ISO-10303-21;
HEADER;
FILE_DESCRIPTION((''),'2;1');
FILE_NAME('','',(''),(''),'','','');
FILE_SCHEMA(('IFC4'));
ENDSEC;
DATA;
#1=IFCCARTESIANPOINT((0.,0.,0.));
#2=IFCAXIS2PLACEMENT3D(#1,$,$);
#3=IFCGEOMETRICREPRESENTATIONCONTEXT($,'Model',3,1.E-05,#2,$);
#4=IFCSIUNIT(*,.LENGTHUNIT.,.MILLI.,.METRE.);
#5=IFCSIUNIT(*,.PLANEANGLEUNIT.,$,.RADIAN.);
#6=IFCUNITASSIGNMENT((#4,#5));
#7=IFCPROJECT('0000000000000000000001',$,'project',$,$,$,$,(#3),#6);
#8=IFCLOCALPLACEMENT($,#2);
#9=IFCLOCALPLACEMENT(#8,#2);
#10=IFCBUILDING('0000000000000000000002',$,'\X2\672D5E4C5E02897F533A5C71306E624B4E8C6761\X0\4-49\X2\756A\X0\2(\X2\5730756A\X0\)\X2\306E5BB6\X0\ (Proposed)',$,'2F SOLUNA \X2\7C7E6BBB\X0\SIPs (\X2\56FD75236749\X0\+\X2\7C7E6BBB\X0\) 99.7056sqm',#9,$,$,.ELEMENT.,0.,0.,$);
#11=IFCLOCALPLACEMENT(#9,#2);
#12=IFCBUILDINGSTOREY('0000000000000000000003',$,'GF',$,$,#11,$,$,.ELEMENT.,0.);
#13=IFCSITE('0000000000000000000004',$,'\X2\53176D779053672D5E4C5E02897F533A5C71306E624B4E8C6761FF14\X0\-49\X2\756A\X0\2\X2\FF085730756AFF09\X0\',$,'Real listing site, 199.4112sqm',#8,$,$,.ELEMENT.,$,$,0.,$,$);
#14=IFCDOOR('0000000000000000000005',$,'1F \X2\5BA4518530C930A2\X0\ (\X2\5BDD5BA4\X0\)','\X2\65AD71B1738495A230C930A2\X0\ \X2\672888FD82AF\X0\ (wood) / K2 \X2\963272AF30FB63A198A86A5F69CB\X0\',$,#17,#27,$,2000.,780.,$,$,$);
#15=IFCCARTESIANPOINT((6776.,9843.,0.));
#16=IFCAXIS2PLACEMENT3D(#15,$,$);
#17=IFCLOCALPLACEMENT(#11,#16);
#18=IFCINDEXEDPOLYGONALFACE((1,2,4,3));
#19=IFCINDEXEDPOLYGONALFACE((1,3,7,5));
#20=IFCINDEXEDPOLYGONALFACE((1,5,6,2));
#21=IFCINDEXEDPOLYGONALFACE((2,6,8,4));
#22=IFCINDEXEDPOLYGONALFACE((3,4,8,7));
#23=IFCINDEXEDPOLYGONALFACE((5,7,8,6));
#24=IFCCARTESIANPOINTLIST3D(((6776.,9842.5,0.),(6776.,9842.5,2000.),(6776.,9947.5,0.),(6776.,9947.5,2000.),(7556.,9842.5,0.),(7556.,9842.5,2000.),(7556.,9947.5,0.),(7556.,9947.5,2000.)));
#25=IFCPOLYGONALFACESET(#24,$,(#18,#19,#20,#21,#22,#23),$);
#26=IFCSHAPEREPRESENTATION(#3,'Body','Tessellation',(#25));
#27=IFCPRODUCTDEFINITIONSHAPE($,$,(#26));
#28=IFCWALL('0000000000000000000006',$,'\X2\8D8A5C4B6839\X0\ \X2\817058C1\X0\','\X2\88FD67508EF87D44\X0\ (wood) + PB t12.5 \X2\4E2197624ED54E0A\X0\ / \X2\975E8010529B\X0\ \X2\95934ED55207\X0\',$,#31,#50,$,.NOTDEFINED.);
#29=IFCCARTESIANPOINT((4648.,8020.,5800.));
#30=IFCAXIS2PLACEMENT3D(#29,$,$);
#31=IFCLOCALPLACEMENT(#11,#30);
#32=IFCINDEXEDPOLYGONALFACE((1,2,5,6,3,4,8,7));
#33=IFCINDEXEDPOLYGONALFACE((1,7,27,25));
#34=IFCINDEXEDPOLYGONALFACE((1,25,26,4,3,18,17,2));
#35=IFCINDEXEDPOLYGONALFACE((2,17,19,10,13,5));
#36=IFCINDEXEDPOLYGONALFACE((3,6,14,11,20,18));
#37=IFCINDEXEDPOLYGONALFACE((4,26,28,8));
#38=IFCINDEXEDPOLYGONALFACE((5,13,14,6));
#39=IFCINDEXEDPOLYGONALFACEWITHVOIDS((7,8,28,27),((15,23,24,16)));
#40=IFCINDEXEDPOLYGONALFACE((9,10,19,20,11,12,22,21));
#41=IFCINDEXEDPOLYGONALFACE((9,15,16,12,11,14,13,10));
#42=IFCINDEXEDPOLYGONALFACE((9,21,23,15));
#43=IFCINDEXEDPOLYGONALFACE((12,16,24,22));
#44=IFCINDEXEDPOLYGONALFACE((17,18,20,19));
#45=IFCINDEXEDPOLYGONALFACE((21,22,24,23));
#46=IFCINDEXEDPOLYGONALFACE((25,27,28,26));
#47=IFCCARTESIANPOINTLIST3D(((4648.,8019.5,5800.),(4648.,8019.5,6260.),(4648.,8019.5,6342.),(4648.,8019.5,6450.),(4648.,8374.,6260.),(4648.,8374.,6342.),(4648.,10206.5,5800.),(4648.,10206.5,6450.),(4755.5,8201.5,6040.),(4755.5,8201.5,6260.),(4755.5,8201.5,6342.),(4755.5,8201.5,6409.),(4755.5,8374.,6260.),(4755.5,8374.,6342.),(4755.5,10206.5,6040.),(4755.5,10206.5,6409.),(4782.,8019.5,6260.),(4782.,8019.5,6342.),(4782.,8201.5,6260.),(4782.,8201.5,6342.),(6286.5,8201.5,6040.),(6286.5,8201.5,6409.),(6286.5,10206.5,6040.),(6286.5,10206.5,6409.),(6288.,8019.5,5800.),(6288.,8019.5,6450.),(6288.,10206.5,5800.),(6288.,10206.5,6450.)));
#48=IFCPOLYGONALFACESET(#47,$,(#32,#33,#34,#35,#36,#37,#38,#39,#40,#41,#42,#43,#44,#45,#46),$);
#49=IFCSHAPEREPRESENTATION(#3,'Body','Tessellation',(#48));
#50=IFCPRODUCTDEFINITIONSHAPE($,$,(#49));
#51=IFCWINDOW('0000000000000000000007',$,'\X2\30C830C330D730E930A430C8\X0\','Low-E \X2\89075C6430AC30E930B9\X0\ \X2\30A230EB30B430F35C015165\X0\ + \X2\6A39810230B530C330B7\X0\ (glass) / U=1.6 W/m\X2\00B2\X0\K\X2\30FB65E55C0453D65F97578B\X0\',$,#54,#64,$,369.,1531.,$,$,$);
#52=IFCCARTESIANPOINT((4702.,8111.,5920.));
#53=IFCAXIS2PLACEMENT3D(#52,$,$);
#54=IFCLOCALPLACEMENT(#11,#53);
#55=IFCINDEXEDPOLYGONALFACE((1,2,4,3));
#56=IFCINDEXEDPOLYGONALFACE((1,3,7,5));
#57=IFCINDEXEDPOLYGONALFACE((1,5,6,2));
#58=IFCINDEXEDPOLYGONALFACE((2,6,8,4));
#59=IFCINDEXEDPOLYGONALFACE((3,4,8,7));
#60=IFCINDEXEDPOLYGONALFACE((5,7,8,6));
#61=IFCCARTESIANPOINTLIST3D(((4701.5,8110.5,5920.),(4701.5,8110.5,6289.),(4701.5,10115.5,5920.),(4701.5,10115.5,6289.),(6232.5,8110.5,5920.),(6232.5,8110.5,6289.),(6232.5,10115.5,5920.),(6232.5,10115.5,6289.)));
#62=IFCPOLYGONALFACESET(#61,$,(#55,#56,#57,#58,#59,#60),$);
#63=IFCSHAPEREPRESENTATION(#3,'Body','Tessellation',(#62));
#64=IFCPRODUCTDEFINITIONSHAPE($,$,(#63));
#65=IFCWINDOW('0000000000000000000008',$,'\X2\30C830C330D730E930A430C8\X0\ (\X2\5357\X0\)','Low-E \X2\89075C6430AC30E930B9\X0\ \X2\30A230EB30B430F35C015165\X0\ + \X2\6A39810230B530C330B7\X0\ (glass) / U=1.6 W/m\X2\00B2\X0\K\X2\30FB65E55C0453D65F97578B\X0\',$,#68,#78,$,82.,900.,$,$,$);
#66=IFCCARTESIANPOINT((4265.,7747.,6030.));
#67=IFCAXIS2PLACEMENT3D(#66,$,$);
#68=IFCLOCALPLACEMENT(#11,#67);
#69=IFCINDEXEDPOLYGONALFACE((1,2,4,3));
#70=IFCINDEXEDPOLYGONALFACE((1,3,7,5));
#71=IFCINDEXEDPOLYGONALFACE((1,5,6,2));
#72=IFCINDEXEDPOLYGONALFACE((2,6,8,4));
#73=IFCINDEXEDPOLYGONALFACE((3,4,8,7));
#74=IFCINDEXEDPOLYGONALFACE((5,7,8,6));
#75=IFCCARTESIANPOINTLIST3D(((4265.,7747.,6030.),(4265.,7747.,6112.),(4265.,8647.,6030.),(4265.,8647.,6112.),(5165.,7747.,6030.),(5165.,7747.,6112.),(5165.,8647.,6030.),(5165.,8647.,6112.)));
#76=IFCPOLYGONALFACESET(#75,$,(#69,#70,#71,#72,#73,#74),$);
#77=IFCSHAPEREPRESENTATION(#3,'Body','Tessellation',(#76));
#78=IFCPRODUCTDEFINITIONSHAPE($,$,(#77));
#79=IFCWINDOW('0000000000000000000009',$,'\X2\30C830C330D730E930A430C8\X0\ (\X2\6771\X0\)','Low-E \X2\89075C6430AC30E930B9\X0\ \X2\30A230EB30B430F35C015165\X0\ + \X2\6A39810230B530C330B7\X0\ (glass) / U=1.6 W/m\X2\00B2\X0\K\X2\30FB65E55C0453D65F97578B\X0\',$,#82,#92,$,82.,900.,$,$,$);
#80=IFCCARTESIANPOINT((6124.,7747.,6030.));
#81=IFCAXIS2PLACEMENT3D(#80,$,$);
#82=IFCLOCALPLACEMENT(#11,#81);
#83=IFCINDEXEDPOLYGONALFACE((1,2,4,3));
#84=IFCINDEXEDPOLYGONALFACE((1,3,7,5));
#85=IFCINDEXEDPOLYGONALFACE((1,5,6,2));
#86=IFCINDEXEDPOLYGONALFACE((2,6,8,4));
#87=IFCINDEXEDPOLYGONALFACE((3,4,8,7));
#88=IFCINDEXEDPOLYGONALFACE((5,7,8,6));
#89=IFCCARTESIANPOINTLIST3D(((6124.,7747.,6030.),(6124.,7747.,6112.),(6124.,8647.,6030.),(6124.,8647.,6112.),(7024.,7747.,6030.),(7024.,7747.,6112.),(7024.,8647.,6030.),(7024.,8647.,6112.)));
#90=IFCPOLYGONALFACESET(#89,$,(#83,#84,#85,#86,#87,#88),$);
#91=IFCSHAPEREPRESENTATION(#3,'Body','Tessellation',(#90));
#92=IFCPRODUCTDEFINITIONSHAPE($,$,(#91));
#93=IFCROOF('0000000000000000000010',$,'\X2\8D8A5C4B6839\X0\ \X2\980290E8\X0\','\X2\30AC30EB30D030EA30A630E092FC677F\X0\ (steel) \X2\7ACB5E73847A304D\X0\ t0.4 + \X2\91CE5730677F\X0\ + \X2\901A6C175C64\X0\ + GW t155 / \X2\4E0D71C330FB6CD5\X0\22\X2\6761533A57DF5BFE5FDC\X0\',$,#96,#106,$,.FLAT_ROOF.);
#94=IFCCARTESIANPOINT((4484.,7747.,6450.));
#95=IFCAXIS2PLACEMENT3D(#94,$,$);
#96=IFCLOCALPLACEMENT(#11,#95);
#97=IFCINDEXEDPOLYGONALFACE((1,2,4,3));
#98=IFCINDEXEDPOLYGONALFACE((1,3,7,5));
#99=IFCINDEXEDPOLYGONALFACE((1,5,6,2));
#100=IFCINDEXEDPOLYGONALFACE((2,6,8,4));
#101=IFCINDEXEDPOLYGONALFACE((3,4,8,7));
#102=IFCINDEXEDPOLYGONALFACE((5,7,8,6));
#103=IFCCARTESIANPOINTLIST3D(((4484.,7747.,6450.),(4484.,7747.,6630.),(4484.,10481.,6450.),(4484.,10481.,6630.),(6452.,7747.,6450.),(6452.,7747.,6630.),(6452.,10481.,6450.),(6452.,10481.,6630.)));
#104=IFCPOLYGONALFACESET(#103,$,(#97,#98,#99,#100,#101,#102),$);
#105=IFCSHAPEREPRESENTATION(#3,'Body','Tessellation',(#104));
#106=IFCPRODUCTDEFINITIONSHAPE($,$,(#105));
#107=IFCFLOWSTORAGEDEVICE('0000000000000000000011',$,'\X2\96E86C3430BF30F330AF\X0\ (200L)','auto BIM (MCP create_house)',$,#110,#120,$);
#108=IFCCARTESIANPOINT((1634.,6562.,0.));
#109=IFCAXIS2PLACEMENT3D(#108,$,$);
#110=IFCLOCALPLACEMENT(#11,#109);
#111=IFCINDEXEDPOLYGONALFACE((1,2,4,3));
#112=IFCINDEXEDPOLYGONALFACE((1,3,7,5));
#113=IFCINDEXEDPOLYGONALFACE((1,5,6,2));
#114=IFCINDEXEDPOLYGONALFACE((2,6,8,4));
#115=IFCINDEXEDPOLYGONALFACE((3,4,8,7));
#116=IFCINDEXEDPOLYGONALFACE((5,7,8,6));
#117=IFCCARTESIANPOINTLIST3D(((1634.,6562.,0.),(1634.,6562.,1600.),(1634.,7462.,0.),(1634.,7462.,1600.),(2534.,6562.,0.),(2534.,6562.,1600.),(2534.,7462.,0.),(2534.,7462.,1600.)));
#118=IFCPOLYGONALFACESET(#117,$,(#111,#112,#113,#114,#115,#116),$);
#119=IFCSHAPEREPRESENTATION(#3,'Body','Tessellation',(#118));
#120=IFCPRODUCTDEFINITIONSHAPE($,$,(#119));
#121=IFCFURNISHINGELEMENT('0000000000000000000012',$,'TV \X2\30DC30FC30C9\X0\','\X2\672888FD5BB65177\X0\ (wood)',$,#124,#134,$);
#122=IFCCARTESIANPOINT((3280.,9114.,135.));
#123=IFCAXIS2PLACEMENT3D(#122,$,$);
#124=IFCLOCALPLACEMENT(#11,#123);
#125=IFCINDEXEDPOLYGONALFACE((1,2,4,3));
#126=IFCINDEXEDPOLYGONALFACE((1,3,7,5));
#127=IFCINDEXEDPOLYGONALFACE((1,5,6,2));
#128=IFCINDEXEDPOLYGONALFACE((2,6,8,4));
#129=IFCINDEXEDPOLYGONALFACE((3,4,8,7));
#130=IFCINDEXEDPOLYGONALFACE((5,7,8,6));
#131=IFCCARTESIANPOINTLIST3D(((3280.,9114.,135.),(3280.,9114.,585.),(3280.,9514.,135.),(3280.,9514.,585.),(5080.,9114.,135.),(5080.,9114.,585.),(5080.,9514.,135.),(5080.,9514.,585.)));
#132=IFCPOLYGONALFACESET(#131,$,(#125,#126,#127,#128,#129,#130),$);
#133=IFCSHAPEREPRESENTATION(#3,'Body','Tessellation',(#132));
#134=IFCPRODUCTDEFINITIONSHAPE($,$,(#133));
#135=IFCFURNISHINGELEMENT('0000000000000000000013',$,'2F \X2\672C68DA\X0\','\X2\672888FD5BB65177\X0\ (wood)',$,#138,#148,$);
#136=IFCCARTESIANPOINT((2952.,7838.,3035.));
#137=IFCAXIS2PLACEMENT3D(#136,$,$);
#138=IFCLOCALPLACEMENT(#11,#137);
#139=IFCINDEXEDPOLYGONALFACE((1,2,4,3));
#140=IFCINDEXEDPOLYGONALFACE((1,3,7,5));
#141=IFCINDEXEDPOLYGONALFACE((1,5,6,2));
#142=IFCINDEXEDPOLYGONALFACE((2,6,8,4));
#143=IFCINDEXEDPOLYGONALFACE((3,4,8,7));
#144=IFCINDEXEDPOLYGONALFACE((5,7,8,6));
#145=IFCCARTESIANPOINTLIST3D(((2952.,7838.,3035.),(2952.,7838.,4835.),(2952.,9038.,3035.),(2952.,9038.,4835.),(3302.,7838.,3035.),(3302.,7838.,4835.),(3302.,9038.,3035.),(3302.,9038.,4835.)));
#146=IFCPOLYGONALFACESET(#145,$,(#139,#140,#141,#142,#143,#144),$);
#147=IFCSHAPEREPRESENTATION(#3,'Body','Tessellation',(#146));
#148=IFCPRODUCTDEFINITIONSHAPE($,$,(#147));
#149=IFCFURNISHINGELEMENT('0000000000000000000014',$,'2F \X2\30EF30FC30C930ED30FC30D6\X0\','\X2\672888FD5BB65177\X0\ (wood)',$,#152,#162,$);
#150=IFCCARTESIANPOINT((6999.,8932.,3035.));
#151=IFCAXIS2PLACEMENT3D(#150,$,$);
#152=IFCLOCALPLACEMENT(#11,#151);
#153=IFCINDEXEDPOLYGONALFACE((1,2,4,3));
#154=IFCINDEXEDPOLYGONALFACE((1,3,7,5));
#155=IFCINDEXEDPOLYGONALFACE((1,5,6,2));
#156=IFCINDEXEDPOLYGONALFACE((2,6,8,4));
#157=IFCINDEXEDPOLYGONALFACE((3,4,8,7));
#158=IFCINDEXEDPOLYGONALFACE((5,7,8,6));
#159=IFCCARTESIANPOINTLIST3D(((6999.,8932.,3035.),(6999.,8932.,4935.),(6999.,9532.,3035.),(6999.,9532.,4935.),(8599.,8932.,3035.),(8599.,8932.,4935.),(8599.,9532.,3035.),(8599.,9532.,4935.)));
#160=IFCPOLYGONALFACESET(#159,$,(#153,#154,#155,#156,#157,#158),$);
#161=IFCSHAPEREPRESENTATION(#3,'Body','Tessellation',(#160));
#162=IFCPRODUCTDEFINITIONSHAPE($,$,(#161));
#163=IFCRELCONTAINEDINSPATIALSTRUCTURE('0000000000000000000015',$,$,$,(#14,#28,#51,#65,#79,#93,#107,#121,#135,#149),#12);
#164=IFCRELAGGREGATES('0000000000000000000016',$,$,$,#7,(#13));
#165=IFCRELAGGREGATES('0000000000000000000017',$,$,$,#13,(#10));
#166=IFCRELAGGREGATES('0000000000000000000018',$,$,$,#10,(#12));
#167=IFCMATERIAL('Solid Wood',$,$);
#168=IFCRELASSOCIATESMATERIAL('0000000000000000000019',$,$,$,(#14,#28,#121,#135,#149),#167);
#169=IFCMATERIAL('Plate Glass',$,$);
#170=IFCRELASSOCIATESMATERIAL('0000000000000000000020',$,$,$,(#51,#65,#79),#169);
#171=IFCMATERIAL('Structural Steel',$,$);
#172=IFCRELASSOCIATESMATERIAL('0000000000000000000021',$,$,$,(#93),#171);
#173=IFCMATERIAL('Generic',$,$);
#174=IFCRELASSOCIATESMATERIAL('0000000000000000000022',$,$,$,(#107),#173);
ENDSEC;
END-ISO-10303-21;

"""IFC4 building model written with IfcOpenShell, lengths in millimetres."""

from ifc_helpers import new_model, si_unit, frame, frame_2d, origin, place, context, project, spatial, rectangle, extrude, material, element, fill, save


model = new_model("IFC4")

# Units and contexts
model_context = context("Model", 3, precision=1e-05, world=origin())
ifc_project = project(units=[si_unit("LENGTHUNIT", "METRE", prefix="MILLI"), si_unit("PLANEANGLEUNIT", "RADIAN")], contexts=[model_context])

# Site, building, storey
site_placement = place(None, origin())
site = spatial("IfcSite", under=ifc_project, at=site_placement, Name="北海道札幌市西区山の手二条４-49番2（地番）", ObjectType="Real listing site, 199.4112sqm", CompositionType="ELEMENT", RefElevation=0.0)
building_placement = place(site_placement, origin())
building = spatial("IfcBuilding", under=site, at=building_placement, Name="札幌市西区山の手二条4-49番2(地番)の家 (Proposed)", ObjectType="2F SOLUNA 籾殻SIPs (国産杉+籾殻) 99.7056sqm", CompositionType="ELEMENT", ElevationOfRefHeight=0.0, ElevationOfTerrain=0.0)
storey_placement = place(building_placement, origin())
storey = spatial("IfcBuildingStorey", under=building, at=storey_placement, Name="GF", CompositionType="ELEMENT", Elevation=0.0)

# Shared definitions
ifc_material_1 = material(Name="Solid Wood")

# Door
door_placement = place(storey_placement, frame((6776.0, 9843.0, 0.0)))
element("IfcDoor", 1, at=door_placement, inside=storey, material=ifc_material_1, Name="1F 室内ドア (寝室)", Description="断熱玄関ドア 木製芯 (wood) / K2 防犯・採風機構", OverallHeight=2000.0, OverallWidth=780.0, context=model_context, shape_type="SweptSolid", body=[
    extrude(rectangle(XDim=780.0, YDim=105.0, at=frame_2d((390.0, 52.0))), frame((6776.0, 9843.0, 0.0)), (0.0, 0.0, 1.0), 2000.0),
])

# Wall, openings, windows
wall_1_placement = place(storey_placement, frame((4648.0, 8020.0, 5800.0)))
wall_1 = element("IfcWall", 2, at=wall_1_placement, inside=storey, material=ifc_material_1, Name="越屋根 腰壁", Description="製材軸組 (wood) + PB t12.5 両面仕上 / 非耐力 間仕切", PredefinedType="NOTDEFINED", context=model_context, shape_type="SweptSolid", body=[
    extrude(rectangle(XDim=1640.0, YDim=2187.0, at=frame_2d((820.0, 1093.0))), frame((4648.0, 8020.0, 5800.0)), (0.0, 0.0, 1.0), 650.0),
])
opening_1_placement = place(storey_placement, frame((4702.0, 8111.0, 5920.0)))
opening_1 = element("IfcOpeningElement", 3, at=opening_1_placement, cuts=wall_1, PredefinedType="NOTDEFINED", context=model_context, shape_type="SweptSolid", body=[
    extrude(rectangle(XDim=1531.0, YDim=2005.0, at=frame_2d((765.0, 1002.0))), frame((4702.0, 8111.0, 5920.0)), (0.0, 0.0, 1.0), 369.0),
])
opening_2_placement = place(storey_placement, frame((4265.0, 7747.0, 6030.0)))
opening_2 = element("IfcOpeningElement", 4, at=opening_2_placement, cuts=wall_1, PredefinedType="NOTDEFINED", context=model_context, shape_type="SweptSolid", body=[
    extrude(rectangle(XDim=900.0, YDim=900.0, at=frame_2d((450.0, 450.0))), frame((4265.0, 7747.0, 6030.0)), (0.0, 0.0, 1.0), 82.0),
])
opening_3_placement = place(storey_placement, frame((6124.0, 7747.0, 6030.0)))
opening_3 = element("IfcOpeningElement", 5, at=opening_3_placement, cuts=wall_1, PredefinedType="NOTDEFINED", context=model_context, shape_type="SweptSolid", body=[
    extrude(rectangle(XDim=900.0, YDim=900.0, at=frame_2d((450.0, 450.0))), frame((6124.0, 7747.0, 6030.0)), (0.0, 0.0, 1.0), 82.0),
])
ifc_material_2 = material(Name="Plate Glass")
window_1_placement = place(storey_placement, frame((4702.0, 8111.0, 5920.0)))
window_1 = element("IfcWindow", 6, at=window_1_placement, inside=storey, material=ifc_material_2, Name="トップライト", Description="Low-E 複層ガラス アルゴン封入 + 樹脂サッシ (glass) / U=1.6 W/m²K・日射取得型", OverallHeight=369.0, OverallWidth=1531.0, context=model_context, shape_type="SweptSolid", body=[
    extrude(rectangle(XDim=1531.0, YDim=2005.0, at=frame_2d((765.0, 1002.0))), frame((4702.0, 8111.0, 5920.0)), (0.0, 0.0, 1.0), 369.0),
])
fill(opening_1, window_1)
window_2_placement = place(storey_placement, frame((4265.0, 7747.0, 6030.0)))
window_2 = element("IfcWindow", 7, at=window_2_placement, inside=storey, material=ifc_material_2, Name="トップライト (南)", Description="Low-E 複層ガラス アルゴン封入 + 樹脂サッシ (glass) / U=1.6 W/m²K・日射取得型", OverallHeight=82.0, OverallWidth=900.0, context=model_context, shape_type="SweptSolid", body=[
    extrude(rectangle(XDim=900.0, YDim=900.0, at=frame_2d((450.0, 450.0))), frame((4265.0, 7747.0, 6030.0)), (0.0, 0.0, 1.0), 82.0),
])
fill(opening_2, window_2)
window_3_placement = place(storey_placement, frame((6124.0, 7747.0, 6030.0)))
window_3 = element("IfcWindow", 8, at=window_3_placement, inside=storey, material=ifc_material_2, Name="トップライト (東)", Description="Low-E 複層ガラス アルゴン封入 + 樹脂サッシ (glass) / U=1.6 W/m²K・日射取得型", OverallHeight=82.0, OverallWidth=900.0, context=model_context, shape_type="SweptSolid", body=[
    extrude(rectangle(XDim=900.0, YDim=900.0, at=frame_2d((450.0, 450.0))), frame((6124.0, 7747.0, 6030.0)), (0.0, 0.0, 1.0), 82.0),
])
fill(opening_3, window_3)

# Roof
ifc_material_3 = material(Name="Structural Steel")
roof_placement = place(storey_placement, frame((4484.0, 7747.0, 6450.0)))
element("IfcRoof", 9, at=roof_placement, inside=storey, material=ifc_material_3, Name="越屋根 頂部", Description="ガルバリウム鋼板 (steel) 立平葺き t0.4 + 野地板 + 通気層 + GW t155 / 不燃・法22条区域対応", PredefinedType="FLAT_ROOF", context=model_context, shape_type="SweptSolid", body=[
    extrude(rectangle(XDim=1968.0, YDim=2734.0, at=frame_2d((984.0, 1367.0))), frame((4484.0, 7747.0, 6450.0)), (0.0, 0.0, 1.0), 180.0),
])

# Flow storage device
ifc_material_4 = material(Name="Generic")
flow_storage_device_placement = place(storey_placement, frame((1634.0, 6562.0, 0.0)))
element("IfcFlowStorageDevice", 10, at=flow_storage_device_placement, inside=storey, material=ifc_material_4, Name="雨水タンク (200L)", Description="auto BIM (MCP create_house)", context=model_context, shape_type="SweptSolid", body=[
    extrude(rectangle(XDim=900.0, YDim=900.0, at=frame_2d((450.0, 450.0))), frame((1634.0, 6562.0, 0.0)), (0.0, 0.0, 1.0), 1600.0),
])

# Furnishing elements
furnishing_1_placement = place(storey_placement, frame((3280.0, 9114.0, 135.0)))
element("IfcFurnishingElement", 11, at=furnishing_1_placement, inside=storey, material=ifc_material_1, Name="TV ボード", Description="木製家具 (wood)", context=model_context, shape_type="SweptSolid", body=[
    extrude(rectangle(XDim=1800.0, YDim=400.0, at=frame_2d((900.0, 200.0))), frame((3280.0, 9114.0, 135.0)), (0.0, 0.0, 1.0), 450.0),
])
furnishing_2_placement = place(storey_placement, frame((2952.0, 7838.0, 3035.0)))
element("IfcFurnishingElement", 12, at=furnishing_2_placement, inside=storey, material=ifc_material_1, Name="2F 本棚", Description="木製家具 (wood)", context=model_context, shape_type="SweptSolid", body=[
    extrude(rectangle(XDim=350.0, YDim=1200.0, at=frame_2d((175.0, 600.0))), frame((2952.0, 7838.0, 3035.0)), (0.0, 0.0, 1.0), 1800.0),
])
furnishing_3_placement = place(storey_placement, frame((6999.0, 8932.0, 3035.0)))
element("IfcFurnishingElement", 13, at=furnishing_3_placement, inside=storey, material=ifc_material_1, Name="2F ワードローブ", Description="木製家具 (wood)", context=model_context, shape_type="SweptSolid", body=[
    extrude(rectangle(XDim=1600.0, YDim=600.0, at=frame_2d((800.0, 300.0))), frame((6999.0, 8932.0, 3035.0)), (0.0, 0.0, 1.0), 1900.0),
])

save(model, "model.ifc")
